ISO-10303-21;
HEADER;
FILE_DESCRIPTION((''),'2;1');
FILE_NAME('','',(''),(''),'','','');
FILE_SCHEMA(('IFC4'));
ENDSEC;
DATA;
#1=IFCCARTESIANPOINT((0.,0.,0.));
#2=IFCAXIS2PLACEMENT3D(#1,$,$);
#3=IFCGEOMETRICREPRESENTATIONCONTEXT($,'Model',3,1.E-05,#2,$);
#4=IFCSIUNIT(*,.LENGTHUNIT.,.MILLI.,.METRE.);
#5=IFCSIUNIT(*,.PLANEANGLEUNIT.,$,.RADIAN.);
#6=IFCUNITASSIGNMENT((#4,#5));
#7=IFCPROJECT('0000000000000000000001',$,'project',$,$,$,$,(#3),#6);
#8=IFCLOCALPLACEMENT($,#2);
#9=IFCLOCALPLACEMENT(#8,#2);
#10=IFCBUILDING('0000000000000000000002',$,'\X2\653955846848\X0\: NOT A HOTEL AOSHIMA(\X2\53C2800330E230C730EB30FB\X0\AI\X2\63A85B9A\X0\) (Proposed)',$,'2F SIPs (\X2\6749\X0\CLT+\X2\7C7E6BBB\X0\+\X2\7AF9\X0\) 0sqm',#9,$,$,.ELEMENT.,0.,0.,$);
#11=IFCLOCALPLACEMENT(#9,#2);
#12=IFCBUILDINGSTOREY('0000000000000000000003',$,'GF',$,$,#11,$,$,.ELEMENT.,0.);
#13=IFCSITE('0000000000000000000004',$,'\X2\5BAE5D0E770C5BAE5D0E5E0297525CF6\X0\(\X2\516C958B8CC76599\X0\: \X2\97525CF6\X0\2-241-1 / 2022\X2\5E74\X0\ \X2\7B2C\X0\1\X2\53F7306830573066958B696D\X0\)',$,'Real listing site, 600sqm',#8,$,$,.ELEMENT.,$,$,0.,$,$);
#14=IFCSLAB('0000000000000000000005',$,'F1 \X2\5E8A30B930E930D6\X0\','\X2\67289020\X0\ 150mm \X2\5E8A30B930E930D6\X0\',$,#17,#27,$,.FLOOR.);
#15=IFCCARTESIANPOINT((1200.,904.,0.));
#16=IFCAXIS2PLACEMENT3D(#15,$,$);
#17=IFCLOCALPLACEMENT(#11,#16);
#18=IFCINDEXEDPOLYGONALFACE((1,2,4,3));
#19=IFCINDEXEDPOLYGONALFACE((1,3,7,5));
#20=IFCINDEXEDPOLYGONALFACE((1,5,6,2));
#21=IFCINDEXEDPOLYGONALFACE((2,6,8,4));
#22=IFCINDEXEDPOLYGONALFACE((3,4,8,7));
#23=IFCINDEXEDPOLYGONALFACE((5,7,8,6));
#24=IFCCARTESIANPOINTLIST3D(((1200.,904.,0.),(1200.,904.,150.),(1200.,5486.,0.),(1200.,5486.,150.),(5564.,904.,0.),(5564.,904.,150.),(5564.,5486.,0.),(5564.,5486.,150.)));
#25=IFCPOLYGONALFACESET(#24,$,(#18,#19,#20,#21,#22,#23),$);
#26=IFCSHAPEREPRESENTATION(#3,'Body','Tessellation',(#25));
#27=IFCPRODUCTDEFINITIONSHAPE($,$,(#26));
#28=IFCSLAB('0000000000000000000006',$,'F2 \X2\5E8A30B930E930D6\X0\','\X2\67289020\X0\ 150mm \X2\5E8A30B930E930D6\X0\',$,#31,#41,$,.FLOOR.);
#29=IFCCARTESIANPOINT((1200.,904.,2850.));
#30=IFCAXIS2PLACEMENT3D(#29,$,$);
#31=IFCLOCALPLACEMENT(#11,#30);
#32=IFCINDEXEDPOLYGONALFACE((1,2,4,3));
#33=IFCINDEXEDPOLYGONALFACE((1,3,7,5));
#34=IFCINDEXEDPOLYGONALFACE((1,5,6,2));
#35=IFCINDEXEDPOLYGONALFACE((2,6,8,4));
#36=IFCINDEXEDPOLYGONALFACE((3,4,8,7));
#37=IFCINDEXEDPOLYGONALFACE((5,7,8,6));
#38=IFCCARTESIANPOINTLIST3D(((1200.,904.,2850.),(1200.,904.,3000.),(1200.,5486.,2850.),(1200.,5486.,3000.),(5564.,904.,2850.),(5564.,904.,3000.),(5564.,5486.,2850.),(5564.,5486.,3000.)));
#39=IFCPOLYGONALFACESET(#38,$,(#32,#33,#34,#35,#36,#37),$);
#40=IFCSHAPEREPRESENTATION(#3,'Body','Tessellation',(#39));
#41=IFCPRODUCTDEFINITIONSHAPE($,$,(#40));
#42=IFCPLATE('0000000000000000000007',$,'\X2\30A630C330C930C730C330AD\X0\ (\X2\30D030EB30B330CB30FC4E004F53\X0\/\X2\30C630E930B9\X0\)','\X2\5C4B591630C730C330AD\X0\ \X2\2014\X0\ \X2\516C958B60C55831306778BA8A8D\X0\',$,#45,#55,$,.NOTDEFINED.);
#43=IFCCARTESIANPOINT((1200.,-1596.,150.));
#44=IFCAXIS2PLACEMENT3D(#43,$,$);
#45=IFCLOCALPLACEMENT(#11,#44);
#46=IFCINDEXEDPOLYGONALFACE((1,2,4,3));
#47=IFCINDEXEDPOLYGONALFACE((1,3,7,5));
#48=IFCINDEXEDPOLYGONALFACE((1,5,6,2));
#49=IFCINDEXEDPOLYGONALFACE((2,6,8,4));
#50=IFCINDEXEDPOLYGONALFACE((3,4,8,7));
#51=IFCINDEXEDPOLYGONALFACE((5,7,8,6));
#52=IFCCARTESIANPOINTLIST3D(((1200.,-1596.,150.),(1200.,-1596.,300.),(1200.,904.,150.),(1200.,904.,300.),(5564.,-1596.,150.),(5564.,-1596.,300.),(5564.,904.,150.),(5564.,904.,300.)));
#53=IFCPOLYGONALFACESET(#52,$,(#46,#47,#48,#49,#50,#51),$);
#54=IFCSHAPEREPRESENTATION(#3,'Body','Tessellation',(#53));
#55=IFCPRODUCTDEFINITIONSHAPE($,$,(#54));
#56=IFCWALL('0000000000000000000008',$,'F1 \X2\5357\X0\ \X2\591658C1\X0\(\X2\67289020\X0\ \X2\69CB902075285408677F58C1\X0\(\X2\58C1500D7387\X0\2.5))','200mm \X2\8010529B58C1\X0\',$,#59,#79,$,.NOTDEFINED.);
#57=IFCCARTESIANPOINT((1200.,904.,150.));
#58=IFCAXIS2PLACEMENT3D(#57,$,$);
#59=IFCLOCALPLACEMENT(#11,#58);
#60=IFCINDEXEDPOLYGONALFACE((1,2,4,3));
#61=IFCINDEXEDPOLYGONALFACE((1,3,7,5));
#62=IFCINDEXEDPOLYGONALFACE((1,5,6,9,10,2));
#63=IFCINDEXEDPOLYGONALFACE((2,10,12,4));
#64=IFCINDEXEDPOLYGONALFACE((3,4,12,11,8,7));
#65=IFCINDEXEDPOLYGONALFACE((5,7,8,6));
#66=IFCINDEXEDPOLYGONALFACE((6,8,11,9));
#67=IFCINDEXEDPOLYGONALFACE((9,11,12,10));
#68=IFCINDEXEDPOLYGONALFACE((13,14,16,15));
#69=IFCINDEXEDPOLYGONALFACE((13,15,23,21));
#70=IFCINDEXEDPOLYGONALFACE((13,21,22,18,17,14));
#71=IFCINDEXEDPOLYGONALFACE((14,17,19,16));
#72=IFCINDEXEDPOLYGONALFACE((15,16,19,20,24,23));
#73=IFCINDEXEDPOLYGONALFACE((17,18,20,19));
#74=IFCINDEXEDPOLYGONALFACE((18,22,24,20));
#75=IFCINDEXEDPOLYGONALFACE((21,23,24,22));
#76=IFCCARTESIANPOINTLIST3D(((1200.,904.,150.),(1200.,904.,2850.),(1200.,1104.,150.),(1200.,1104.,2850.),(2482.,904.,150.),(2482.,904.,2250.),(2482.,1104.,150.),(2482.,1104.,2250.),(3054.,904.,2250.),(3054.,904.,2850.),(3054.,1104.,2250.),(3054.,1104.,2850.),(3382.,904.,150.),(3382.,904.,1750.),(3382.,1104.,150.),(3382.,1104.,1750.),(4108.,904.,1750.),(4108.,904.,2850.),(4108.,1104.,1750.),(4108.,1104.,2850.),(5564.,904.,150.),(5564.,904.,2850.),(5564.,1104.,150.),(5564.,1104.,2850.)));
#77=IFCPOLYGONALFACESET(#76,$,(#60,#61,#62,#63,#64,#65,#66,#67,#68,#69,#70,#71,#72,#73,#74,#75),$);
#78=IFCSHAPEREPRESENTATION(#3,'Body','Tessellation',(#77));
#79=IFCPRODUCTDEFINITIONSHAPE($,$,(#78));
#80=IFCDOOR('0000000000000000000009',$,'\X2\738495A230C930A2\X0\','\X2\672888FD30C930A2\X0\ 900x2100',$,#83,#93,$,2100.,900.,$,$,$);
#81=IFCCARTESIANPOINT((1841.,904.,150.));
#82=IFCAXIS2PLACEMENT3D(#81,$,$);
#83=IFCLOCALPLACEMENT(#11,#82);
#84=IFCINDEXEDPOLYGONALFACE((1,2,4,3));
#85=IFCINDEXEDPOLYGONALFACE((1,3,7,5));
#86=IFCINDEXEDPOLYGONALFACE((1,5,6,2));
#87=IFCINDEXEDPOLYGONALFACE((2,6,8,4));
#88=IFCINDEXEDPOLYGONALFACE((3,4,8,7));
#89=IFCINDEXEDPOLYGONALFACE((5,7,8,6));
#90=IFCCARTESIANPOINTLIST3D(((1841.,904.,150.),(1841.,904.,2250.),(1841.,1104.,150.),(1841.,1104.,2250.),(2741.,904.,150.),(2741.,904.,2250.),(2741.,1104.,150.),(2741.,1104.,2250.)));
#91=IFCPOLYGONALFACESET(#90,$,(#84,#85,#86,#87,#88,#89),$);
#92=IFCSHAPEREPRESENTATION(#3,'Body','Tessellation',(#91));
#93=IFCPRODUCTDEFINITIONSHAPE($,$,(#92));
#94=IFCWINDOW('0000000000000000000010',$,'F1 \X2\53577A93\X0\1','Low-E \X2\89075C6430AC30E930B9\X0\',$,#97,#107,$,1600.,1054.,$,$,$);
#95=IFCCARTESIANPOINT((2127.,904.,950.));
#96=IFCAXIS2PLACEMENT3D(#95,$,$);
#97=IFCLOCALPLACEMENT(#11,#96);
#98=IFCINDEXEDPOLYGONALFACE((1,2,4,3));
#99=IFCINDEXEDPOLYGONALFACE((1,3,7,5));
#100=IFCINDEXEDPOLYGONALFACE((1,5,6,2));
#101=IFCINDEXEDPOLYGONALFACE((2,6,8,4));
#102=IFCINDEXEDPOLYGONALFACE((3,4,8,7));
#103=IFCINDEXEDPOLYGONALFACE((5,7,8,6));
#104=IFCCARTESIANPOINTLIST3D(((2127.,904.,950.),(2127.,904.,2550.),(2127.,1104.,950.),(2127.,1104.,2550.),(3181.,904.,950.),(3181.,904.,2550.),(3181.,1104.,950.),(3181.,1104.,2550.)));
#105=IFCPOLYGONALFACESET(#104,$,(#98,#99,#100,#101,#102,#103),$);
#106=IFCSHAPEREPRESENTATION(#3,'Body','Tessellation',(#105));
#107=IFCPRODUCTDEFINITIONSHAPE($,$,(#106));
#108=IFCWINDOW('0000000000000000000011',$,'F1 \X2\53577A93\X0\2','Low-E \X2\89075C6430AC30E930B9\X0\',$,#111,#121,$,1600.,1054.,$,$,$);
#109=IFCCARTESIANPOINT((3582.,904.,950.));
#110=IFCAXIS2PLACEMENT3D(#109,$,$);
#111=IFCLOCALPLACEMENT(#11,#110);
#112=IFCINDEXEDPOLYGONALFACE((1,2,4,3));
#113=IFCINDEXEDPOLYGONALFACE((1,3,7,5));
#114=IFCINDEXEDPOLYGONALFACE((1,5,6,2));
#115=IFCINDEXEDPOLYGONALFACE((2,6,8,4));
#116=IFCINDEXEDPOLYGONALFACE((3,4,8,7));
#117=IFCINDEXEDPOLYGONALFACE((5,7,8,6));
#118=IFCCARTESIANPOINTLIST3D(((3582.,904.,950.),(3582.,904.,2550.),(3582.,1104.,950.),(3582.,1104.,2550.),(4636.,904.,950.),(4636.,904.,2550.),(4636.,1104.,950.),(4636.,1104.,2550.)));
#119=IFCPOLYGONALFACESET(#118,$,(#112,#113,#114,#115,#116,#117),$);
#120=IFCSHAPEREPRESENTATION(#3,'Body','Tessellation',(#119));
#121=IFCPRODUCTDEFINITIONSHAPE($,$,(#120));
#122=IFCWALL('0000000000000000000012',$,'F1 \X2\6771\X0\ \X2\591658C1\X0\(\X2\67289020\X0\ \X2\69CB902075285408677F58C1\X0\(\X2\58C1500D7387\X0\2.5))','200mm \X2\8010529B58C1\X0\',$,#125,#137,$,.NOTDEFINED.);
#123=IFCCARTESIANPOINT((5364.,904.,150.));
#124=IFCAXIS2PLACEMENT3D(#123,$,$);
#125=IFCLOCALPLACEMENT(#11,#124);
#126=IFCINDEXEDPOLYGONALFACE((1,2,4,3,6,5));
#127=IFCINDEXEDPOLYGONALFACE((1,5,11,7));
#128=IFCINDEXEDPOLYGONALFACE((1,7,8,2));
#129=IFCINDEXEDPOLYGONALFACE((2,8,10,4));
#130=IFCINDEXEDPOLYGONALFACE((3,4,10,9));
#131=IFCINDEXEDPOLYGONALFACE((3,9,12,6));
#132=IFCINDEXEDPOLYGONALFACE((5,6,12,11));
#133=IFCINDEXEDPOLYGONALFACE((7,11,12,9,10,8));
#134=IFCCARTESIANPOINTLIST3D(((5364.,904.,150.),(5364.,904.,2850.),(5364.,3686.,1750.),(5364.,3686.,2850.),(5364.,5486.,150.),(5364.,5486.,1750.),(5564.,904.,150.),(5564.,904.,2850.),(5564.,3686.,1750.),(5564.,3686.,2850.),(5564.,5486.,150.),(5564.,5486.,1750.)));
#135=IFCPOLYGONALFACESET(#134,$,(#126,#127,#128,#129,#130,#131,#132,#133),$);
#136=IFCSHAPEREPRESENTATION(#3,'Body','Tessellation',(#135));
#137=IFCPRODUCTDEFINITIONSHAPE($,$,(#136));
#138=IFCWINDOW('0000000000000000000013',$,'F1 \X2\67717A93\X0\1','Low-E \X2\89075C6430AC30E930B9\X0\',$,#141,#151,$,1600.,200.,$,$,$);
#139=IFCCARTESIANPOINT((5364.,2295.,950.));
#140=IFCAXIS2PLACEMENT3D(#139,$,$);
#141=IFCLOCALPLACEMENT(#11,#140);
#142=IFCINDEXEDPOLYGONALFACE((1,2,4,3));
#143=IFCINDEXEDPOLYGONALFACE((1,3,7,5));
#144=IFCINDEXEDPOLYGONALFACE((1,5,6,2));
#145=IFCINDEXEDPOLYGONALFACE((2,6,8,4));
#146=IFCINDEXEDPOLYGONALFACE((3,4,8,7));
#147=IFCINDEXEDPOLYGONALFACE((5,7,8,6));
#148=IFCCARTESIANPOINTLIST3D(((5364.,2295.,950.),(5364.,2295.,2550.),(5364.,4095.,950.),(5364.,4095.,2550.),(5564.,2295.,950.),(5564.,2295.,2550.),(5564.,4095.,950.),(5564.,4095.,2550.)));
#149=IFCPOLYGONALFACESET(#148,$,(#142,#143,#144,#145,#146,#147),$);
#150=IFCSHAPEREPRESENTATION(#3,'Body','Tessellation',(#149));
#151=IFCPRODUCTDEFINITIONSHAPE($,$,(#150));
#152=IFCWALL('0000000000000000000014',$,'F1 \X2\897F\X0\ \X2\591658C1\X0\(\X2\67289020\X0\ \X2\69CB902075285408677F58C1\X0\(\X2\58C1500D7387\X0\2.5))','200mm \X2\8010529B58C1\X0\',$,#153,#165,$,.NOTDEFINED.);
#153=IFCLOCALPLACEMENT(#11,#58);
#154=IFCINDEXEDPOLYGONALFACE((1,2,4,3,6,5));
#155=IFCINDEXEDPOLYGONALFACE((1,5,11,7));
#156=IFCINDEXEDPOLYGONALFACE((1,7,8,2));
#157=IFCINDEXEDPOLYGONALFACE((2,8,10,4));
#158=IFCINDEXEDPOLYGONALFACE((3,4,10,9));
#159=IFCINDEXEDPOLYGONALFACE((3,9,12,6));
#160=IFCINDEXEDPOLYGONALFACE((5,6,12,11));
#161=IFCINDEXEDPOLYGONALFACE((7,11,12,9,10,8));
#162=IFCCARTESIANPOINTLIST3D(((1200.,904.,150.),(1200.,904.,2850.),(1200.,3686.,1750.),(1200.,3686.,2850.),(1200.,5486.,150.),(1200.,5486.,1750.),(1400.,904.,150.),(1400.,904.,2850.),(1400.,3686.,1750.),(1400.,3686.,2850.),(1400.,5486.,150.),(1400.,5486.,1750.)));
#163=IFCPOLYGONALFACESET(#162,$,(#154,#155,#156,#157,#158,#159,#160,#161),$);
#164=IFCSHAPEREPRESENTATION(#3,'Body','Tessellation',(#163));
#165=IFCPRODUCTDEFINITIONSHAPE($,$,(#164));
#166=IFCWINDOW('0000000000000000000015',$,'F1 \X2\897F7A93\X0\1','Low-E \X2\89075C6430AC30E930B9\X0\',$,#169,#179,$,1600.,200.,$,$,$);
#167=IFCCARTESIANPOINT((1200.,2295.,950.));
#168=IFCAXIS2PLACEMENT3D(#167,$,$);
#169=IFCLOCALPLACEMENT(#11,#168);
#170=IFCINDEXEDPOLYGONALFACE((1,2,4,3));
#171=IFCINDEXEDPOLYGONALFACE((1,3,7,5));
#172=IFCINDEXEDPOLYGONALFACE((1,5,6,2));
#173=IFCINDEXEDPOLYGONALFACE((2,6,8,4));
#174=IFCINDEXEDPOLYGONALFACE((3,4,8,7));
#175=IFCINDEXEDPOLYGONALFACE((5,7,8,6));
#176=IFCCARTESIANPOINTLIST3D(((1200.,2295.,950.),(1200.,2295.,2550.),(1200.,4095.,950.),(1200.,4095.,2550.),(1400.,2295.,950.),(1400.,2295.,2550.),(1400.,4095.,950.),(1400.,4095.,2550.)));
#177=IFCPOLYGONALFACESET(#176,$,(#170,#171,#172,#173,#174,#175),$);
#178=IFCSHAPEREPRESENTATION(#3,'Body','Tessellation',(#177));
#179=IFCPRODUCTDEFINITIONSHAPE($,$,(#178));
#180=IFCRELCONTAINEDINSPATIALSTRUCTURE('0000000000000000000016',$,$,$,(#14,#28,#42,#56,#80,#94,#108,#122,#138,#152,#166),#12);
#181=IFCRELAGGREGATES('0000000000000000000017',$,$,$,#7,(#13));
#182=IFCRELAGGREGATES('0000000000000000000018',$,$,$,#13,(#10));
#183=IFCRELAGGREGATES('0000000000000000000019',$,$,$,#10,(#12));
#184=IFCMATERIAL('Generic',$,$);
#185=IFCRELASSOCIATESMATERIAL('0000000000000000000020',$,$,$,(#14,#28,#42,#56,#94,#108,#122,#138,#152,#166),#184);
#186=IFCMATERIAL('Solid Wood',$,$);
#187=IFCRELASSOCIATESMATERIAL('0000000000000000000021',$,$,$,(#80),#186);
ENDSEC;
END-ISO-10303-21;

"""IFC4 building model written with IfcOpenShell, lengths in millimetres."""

from ifc_helpers import new_model, si_unit, frame, frame_2d, origin, place, context, project, spatial, rectangle, extrude, material, element, fill, save


model = new_model("IFC4")

# Units and contexts
model_context = context("Model", 3, precision=1e-05, world=origin())
ifc_project = project(units=[si_unit("LENGTHUNIT", "METRE", prefix="MILLI"), si_unit("PLANEANGLEUNIT", "RADIAN")], contexts=[model_context])

# Site, building, storey
site_placement = place(None, origin())
site = spatial("IfcSite", under=ifc_project, at=site_placement, Name="宮崎県宮崎市青島(公開資料: 青島2-241-1 / 2022年 第1号として開業)", ObjectType="Real listing site, 600sqm", CompositionType="ELEMENT", RefElevation=0.0)
building_placement = place(site_placement, origin())
building = spatial("IfcBuilding", under=site, at=building_placement, Name="改善案: NOT A HOTEL AOSHIMA(参考モデル・AI推定) (Proposed)", ObjectType="2F SIPs (杉CLT+籾殻+竹) 0sqm", CompositionType="ELEMENT", ElevationOfRefHeight=0.0, ElevationOfTerrain=0.0)
storey_placement = place(building_placement, origin())
storey = spatial("IfcBuildingStorey", under=building, at=storey_placement, Name="GF", CompositionType="ELEMENT", Elevation=0.0)

# Slabs
ifc_material_1 = material(Name="Generic")
slab_1_placement = place(storey_placement, frame((1200.0, 904.0, 0.0)))
element("IfcSlab", 1, at=slab_1_placement, inside=storey, material=ifc_material_1, Name="F1 床スラブ", Description="木造 150mm 床スラブ", PredefinedType="FLOOR", context=model_context, shape_type="SweptSolid", body=[
    extrude(rectangle(XDim=4364.0, YDim=4582.0, at=frame_2d((2182.0, 2291.0))), frame((1200.0, 904.0, 0.0)), (0.0, 0.0, 1.0), 150.0),
])
slab_2_placement = place(storey_placement, frame((1200.0, 904.0, 2850.0)))
element("IfcSlab", 2, at=slab_2_placement, inside=storey, material=ifc_material_1, Name="F2 床スラブ", Description="木造 150mm 床スラブ", PredefinedType="FLOOR", context=model_context, shape_type="SweptSolid", body=[
    extrude(rectangle(XDim=4364.0, YDim=4582.0, at=frame_2d((2182.0, 2291.0))), frame((1200.0, 904.0, 2850.0)), (0.0, 0.0, 1.0), 150.0),
])

# Plate
plate_placement = place(storey_placement, frame((1200.0, -1596.0, 150.0)))
element("IfcPlate", 3, at=plate_placement, inside=storey, material=ifc_material_1, Name="ウッドデッキ (バルコニー一体/テラス)", Description="屋外デッキ — 公開情報で確認", PredefinedType="NOTDEFINED", context=model_context, shape_type="SweptSolid", body=[
    extrude(rectangle(XDim=4364.0, YDim=2500.0, at=frame_2d((2182.0, 1250.0))), frame((1200.0, -1596.0, 150.0)), (0.0, 0.0, 1.0), 150.0),
])

# Wall, openings, door, windows
wall_1_placement = place(storey_placement, frame((1200.0, 904.0, 150.0)))
wall_1 = element("IfcWall", 4, at=wall_1_placement, inside=storey, material=ifc_material_1, Name="F1 南 外壁(木造 構造用合板壁(壁倍率2.5))", Description="200mm 耐力壁", PredefinedType="NOTDEFINED", context=model_context, shape_type="SweptSolid", body=[
    extrude(rectangle(XDim=4364.0, YDim=200.0, at=frame_2d((2182.0, 100.0))), frame((1200.0, 904.0, 150.0)), (0.0, 0.0, 1.0), 2700.0),
])
opening_1_placement = place(storey_placement, frame((1841.0, 904.0, 150.0)))
opening_1 = element("IfcOpeningElement", 5, at=opening_1_placement, cuts=wall_1, PredefinedType="NOTDEFINED", context=model_context, shape_type="SweptSolid", body=[
    extrude(rectangle(XDim=900.0, YDim=200.0, at=frame_2d((450.0, 100.0))), frame((1841.0, 904.0, 150.0)), (0.0, 0.0, 1.0), 2100.0),
])
opening_2_placement = place(storey_placement, frame((2127.0, 904.0, 950.0)))
opening_2 = element("IfcOpeningElement", 6, at=opening_2_placement, cuts=wall_1, PredefinedType="NOTDEFINED", context=model_context, shape_type="SweptSolid", body=[
    extrude(rectangle(XDim=1054.0, YDim=200.0, at=frame_2d((527.0, 100.0))), frame((2127.0, 904.0, 950.0)), (0.0, 0.0, 1.0), 1600.0),
])
opening_3_placement = place(storey_placement, frame((3582.0, 904.0, 950.0)))
opening_3 = element("IfcOpeningElement", 7, at=opening_3_placement, cuts=wall_1, PredefinedType="NOTDEFINED", context=model_context, shape_type="SweptSolid", body=[
    extrude(rectangle(XDim=1054.0, YDim=200.0, at=frame_2d((527.0, 100.0))), frame((3582.0, 904.0, 950.0)), (0.0, 0.0, 1.0), 1600.0),
])
ifc_material_2 = material(Name="Solid Wood")
door_placement = place(storey_placement, frame((1841.0, 904.0, 150.0)))
door = element("IfcDoor", 8, at=door_placement, inside=storey, material=ifc_material_2, Name="玄関ドア", Description="木製ドア 900x2100", OverallHeight=2100.0, OverallWidth=900.0, context=model_context, shape_type="SweptSolid", body=[
    extrude(rectangle(XDim=900.0, YDim=200.0, at=frame_2d((450.0, 100.0))), frame((1841.0, 904.0, 150.0)), (0.0, 0.0, 1.0), 2100.0),
])
fill(opening_1, door)
window_1_placement = place(storey_placement, frame((2127.0, 904.0, 950.0)))
window_1 = element("IfcWindow", 9, at=window_1_placement, inside=storey, material=ifc_material_1, Name="F1 南窓1", Description="Low-E 複層ガラス", OverallHeight=1600.0, OverallWidth=1054.0, context=model_context, shape_type="SweptSolid", body=[
    extrude(rectangle(XDim=1054.0, YDim=200.0, at=frame_2d((527.0, 100.0))), frame((2127.0, 904.0, 950.0)), (0.0, 0.0, 1.0), 1600.0),
])
fill(opening_2, window_1)
window_2_placement = place(storey_placement, frame((3582.0, 904.0, 950.0)))
window_2 = element("IfcWindow", 10, at=window_2_placement, inside=storey, material=ifc_material_1, Name="F1 南窓2", Description="Low-E 複層ガラス", OverallHeight=1600.0, OverallWidth=1054.0, context=model_context, shape_type="SweptSolid", body=[
    extrude(rectangle(XDim=1054.0, YDim=200.0, at=frame_2d((527.0, 100.0))), frame((3582.0, 904.0, 950.0)), (0.0, 0.0, 1.0), 1600.0),
])
fill(opening_3, window_2)

# Walls, openings, windows
wall_2_placement = place(storey_placement, frame((5364.0, 904.0, 150.0)))
wall_2 = element("IfcWall", 11, at=wall_2_placement, inside=storey, material=ifc_material_1, Name="F1 東 外壁(木造 構造用合板壁(壁倍率2.5))", Description="200mm 耐力壁", PredefinedType="NOTDEFINED", context=model_context, shape_type="SweptSolid", body=[
    extrude(rectangle(XDim=200.0, YDim=4582.0, at=frame_2d((100.0, 2291.0))), frame((5364.0, 904.0, 150.0)), (0.0, 0.0, 1.0), 2700.0),
])
opening_4_placement = place(storey_placement, frame((5364.0, 2295.0, 950.0)))
opening_4 = element("IfcOpeningElement", 12, at=opening_4_placement, cuts=wall_2, PredefinedType="NOTDEFINED", context=model_context, shape_type="SweptSolid", body=[
    extrude(rectangle(XDim=200.0, YDim=1800.0, at=frame_2d((100.0, 900.0))), frame((5364.0, 2295.0, 950.0)), (0.0, 0.0, 1.0), 1600.0),
])
window_3_placement = place(storey_placement, frame((5364.0, 2295.0, 950.0)))
window_3 = element("IfcWindow", 13, at=window_3_placement, inside=storey, material=ifc_material_1, Name="F1 東窓1", Description="Low-E 複層ガラス", OverallHeight=1600.0, OverallWidth=200.0, context=model_context, shape_type="SweptSolid", body=[
    extrude(rectangle(XDim=200.0, YDim=1800.0, at=frame_2d((100.0, 900.0))), frame((5364.0, 2295.0, 950.0)), (0.0, 0.0, 1.0), 1600.0),
])
fill(opening_4, window_3)
wall_3_placement = place(storey_placement, frame((1200.0, 904.0, 150.0)))
wall_3 = element("IfcWall", 14, at=wall_3_placement, inside=storey, material=ifc_material_1, Name="F1 西 外壁(木造 構造用合板壁(壁倍率2.5))", Description="200mm 耐力壁", PredefinedType="NOTDEFINED", context=model_context, shape_type="SweptSolid", body=[
    extrude(rectangle(XDim=200.0, YDim=4582.0, at=frame_2d((100.0, 2291.0))), frame((1200.0, 904.0, 150.0)), (0.0, 0.0, 1.0), 2700.0),
])
opening_5_placement = place(storey_placement, frame((1200.0, 2295.0, 950.0)))
opening_5 = element("IfcOpeningElement", 15, at=opening_5_placement, cuts=wall_3, PredefinedType="NOTDEFINED", context=model_context, shape_type="SweptSolid", body=[
    extrude(rectangle(XDim=200.0, YDim=1800.0, at=frame_2d((100.0, 900.0))), frame((1200.0, 2295.0, 950.0)), (0.0, 0.0, 1.0), 1600.0),
])
window_4_placement = place(storey_placement, frame((1200.0, 2295.0, 950.0)))
window_4 = element("IfcWindow", 16, at=window_4_placement, inside=storey, material=ifc_material_1, Name="F1 西窓1", Description="Low-E 複層ガラス", OverallHeight=1600.0, OverallWidth=200.0, context=model_context, shape_type="SweptSolid", body=[
    extrude(rectangle(XDim=200.0, YDim=1800.0, at=frame_2d((100.0, 900.0))), frame((1200.0, 2295.0, 950.0)), (0.0, 0.0, 1.0), 1600.0),
])
fill(opening_5, window_4)

save(model, "model.ifc")
